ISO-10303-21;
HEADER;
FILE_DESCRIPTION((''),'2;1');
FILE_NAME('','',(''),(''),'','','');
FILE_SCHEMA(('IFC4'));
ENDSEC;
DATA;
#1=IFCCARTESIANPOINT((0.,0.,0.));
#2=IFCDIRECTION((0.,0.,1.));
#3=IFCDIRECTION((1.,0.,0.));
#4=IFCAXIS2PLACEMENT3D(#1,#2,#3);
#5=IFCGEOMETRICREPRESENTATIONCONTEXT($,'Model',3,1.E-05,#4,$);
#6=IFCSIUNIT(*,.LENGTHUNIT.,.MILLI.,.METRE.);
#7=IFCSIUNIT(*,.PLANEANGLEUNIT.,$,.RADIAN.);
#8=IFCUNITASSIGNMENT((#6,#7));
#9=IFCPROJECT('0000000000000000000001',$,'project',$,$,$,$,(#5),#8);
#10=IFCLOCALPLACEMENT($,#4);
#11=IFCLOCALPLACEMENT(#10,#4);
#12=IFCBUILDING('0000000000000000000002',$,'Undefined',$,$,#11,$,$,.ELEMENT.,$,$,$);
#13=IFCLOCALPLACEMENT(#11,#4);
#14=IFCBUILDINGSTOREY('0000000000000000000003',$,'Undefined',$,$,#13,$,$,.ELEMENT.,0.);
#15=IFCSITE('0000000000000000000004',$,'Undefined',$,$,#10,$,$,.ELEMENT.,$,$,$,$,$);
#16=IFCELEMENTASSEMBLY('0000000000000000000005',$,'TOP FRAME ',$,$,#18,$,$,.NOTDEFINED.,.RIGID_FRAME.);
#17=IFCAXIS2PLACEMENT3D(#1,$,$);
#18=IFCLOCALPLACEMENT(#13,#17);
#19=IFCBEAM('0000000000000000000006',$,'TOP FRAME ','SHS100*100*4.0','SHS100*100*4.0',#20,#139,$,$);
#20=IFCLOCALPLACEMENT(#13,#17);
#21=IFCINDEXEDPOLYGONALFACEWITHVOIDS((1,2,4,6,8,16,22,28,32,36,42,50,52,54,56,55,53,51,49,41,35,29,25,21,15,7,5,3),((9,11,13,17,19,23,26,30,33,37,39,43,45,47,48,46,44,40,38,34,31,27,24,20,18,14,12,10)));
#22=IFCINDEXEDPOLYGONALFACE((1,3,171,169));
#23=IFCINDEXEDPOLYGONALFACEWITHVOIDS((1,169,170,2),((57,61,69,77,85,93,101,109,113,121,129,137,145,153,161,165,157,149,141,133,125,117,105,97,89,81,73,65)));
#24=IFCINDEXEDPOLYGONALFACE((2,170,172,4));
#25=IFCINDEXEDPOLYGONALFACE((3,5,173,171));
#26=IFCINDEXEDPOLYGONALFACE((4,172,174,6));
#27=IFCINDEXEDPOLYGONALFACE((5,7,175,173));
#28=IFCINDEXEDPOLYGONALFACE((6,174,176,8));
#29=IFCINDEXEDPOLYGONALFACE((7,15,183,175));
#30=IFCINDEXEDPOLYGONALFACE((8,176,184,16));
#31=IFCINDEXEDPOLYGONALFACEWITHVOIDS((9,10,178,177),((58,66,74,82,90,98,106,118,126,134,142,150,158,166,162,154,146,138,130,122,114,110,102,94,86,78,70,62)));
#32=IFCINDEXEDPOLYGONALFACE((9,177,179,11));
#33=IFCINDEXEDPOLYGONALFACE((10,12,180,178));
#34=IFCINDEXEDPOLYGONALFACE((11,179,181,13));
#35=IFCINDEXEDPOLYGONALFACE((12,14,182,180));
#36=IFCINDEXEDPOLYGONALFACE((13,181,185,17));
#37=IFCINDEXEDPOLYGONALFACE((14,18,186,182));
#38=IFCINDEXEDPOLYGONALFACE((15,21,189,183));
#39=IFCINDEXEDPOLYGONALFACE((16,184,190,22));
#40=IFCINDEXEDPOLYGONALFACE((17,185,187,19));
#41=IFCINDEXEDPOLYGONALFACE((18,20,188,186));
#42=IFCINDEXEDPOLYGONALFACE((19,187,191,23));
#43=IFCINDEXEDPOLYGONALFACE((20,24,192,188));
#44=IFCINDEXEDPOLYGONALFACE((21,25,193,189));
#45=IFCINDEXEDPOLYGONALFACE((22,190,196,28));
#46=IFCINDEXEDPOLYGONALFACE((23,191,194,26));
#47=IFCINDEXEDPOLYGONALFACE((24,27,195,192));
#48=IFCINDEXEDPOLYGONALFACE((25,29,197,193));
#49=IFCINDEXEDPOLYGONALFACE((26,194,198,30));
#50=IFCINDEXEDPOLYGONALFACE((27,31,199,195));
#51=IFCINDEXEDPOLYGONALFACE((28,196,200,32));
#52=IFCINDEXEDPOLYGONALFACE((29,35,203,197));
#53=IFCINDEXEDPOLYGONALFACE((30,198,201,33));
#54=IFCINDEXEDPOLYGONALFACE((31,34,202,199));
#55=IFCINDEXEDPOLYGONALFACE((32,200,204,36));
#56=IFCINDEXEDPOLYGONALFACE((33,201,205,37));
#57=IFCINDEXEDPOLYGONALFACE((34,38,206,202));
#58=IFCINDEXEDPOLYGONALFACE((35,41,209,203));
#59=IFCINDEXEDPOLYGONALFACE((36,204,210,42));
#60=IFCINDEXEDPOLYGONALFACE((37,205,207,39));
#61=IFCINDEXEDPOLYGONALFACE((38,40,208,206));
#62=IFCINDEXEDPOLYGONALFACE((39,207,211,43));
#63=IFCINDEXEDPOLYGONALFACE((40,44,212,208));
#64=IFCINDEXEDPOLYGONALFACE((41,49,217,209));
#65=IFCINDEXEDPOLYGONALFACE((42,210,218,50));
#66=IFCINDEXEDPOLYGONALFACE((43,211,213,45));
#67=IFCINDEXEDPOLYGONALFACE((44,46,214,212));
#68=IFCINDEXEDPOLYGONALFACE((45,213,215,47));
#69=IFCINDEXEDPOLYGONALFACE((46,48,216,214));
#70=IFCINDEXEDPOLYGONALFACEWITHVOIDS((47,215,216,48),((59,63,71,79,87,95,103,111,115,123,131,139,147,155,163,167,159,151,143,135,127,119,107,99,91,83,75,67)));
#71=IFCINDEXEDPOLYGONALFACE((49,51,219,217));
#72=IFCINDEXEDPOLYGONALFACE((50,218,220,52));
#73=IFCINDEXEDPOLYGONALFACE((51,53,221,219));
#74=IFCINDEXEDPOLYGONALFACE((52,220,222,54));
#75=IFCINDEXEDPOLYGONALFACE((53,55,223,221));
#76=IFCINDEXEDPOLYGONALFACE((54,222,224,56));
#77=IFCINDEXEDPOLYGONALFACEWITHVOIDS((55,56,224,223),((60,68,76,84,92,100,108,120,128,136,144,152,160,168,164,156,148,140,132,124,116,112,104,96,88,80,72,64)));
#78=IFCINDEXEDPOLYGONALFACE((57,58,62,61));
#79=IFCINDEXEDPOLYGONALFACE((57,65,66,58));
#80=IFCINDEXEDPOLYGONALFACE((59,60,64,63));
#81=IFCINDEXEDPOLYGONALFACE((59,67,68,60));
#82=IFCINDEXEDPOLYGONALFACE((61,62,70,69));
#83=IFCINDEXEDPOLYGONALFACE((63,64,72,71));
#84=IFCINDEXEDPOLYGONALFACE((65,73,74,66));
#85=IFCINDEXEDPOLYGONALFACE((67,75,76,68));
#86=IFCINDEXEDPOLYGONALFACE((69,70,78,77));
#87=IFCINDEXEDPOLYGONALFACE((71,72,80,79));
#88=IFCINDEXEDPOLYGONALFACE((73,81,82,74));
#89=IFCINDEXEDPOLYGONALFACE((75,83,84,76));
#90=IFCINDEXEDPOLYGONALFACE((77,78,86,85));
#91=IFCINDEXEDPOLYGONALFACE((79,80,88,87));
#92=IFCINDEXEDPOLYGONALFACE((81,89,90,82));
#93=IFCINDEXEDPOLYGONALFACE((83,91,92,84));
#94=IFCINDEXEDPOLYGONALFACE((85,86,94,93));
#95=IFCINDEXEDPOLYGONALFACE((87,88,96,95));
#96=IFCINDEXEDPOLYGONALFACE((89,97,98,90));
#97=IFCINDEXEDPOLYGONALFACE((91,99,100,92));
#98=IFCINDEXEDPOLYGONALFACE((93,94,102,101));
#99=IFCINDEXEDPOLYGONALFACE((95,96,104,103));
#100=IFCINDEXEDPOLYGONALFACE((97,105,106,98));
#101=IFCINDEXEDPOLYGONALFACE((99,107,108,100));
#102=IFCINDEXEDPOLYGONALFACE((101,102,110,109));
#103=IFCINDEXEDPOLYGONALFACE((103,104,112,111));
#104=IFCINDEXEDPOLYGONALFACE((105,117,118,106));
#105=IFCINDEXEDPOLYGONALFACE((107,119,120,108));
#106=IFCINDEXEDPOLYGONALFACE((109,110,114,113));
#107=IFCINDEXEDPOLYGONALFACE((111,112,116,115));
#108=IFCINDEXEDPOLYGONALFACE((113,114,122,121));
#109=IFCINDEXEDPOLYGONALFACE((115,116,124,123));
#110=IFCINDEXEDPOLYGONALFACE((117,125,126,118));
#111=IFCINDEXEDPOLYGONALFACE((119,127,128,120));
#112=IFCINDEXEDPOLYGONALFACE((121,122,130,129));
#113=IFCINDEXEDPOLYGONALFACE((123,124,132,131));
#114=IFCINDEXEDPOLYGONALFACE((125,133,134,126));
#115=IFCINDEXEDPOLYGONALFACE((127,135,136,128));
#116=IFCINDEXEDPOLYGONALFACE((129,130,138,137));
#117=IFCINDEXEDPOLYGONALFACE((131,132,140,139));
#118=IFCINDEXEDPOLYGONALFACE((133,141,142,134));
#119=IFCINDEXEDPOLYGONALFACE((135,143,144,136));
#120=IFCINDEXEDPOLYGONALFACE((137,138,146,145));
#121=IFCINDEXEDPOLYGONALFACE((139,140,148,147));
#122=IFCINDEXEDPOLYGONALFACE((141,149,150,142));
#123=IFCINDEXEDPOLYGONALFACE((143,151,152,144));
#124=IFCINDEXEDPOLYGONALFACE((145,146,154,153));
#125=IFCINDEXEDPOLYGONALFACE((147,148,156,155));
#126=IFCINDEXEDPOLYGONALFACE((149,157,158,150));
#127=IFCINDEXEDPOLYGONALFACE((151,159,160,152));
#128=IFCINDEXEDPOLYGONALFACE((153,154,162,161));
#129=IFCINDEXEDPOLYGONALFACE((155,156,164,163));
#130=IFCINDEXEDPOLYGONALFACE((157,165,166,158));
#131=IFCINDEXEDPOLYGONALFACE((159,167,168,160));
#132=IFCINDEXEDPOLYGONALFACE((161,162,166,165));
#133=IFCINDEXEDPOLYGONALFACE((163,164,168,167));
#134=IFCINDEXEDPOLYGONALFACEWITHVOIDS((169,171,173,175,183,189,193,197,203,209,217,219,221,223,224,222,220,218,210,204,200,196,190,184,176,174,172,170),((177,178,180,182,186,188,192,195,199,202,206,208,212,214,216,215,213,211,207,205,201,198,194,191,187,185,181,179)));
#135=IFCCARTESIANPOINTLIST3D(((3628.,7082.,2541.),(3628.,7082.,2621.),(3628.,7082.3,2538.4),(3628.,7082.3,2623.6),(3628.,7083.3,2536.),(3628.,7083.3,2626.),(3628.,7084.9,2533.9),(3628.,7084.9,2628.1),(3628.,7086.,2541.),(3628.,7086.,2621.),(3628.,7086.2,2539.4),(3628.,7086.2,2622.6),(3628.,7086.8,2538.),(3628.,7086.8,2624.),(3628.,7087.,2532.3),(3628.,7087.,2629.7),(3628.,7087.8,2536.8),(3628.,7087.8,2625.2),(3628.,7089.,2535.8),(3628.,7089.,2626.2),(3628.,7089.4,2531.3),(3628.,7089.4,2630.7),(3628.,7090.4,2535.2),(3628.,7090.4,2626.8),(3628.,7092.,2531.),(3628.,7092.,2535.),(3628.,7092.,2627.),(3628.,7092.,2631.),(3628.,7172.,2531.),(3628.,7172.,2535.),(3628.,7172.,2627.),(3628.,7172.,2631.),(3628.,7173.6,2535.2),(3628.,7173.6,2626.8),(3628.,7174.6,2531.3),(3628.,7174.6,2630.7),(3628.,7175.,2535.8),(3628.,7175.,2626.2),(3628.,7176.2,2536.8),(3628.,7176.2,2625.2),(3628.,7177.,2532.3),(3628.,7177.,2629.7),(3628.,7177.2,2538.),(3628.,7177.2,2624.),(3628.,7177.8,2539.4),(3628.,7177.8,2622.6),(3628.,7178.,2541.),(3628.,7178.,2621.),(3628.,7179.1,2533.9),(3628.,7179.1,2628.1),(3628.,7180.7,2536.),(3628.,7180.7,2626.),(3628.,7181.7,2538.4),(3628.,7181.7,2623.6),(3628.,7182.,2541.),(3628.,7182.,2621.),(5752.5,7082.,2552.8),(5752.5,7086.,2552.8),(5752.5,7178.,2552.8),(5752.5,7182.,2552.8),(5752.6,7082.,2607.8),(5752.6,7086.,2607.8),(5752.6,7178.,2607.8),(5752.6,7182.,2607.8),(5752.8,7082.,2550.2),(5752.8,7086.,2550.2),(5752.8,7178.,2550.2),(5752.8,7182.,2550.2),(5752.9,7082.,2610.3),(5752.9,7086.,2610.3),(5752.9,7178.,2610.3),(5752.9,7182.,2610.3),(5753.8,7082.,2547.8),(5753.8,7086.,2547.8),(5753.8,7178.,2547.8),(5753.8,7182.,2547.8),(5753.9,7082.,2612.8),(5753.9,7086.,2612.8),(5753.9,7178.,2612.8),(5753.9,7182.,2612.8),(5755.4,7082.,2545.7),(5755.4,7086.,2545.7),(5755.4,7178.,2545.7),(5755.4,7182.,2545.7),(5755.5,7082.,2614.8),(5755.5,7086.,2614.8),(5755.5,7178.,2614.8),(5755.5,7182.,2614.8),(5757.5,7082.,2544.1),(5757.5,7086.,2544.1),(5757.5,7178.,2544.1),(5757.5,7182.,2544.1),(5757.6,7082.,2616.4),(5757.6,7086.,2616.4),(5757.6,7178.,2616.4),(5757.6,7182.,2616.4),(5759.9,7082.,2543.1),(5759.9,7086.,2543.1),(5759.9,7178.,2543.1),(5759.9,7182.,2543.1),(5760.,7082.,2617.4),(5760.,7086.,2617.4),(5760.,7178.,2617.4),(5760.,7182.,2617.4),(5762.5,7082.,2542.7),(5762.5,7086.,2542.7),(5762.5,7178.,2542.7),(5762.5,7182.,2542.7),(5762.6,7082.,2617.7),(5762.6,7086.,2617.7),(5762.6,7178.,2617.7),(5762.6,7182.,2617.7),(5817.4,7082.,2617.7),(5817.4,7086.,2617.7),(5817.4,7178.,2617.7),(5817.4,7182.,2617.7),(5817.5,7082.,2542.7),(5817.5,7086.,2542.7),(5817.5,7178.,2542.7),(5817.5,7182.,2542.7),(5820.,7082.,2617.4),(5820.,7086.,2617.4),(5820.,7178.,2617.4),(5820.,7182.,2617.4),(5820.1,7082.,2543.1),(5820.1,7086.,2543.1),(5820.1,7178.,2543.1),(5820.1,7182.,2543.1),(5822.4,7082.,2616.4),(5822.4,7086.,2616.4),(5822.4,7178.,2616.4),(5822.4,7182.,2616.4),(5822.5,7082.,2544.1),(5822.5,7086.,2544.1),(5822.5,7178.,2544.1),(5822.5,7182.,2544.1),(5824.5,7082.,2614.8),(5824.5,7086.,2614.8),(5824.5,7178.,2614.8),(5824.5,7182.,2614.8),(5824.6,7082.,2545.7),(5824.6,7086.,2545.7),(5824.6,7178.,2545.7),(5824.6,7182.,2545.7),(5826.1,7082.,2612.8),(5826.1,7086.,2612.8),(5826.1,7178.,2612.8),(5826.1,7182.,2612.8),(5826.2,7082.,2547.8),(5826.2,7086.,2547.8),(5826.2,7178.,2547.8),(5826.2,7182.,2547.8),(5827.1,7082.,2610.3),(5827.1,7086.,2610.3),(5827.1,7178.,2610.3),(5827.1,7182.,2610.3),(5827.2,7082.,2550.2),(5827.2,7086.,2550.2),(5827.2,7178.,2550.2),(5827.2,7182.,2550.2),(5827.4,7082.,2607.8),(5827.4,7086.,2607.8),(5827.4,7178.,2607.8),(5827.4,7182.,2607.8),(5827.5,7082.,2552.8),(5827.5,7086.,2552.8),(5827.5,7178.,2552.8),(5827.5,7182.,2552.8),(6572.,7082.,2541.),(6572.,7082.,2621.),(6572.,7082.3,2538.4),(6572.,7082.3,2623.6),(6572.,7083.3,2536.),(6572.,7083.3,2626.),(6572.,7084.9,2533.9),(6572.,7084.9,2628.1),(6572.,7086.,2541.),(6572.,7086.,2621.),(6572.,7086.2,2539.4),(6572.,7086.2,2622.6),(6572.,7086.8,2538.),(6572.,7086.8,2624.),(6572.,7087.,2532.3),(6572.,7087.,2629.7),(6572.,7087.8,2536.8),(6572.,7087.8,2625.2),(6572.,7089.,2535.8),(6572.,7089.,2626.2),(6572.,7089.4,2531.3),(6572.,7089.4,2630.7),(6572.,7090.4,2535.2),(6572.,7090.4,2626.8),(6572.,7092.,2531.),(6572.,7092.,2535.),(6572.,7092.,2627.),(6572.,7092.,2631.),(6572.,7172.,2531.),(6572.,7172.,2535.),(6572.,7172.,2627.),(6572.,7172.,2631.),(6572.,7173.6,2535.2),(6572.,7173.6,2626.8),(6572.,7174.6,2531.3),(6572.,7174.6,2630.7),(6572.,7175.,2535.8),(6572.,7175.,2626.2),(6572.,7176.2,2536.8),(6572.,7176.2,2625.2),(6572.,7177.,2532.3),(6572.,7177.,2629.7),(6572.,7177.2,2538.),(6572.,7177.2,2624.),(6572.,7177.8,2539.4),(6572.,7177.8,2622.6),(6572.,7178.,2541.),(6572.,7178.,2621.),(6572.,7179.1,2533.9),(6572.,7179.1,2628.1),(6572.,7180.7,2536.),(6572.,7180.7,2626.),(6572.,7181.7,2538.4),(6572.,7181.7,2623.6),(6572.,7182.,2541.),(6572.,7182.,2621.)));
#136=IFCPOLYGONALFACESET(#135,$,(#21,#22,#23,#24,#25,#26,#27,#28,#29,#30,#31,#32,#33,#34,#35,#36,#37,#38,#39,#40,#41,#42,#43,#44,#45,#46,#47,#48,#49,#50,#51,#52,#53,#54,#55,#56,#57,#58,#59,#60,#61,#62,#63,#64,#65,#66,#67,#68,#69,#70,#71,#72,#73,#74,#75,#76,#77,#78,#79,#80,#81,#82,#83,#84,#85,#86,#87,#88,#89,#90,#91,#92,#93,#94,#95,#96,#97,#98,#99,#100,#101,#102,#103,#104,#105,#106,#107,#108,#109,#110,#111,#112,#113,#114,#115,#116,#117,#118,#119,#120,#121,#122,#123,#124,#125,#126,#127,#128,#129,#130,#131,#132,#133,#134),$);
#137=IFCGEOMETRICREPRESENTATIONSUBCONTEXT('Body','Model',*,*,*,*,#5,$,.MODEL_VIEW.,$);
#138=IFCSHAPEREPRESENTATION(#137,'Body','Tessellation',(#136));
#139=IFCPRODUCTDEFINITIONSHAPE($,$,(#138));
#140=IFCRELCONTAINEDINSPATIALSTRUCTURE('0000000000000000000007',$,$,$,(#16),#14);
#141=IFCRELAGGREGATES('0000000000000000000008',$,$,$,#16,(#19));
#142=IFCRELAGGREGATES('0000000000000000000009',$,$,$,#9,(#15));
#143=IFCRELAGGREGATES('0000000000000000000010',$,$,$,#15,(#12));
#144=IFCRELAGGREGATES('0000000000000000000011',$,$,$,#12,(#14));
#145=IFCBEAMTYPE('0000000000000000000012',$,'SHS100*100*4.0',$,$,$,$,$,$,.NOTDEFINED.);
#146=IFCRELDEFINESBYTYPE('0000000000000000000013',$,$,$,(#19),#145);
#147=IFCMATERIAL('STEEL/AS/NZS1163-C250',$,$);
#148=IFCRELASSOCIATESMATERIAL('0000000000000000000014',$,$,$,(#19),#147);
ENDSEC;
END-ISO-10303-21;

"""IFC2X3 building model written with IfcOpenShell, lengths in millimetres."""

from ifc_helpers import new_model, si_unit, frame, frame_2d, origin_with_axes, origin_2d_with_axis, place, context, subcontext, project, spatial, polyline, circle_curve, parameter, trimmed, segment, composite_curve, hollow_rectangle, outline, extrude, boolean, material, type_object, element, aggregate, save


model = new_model("IFC2X3")

# Units and contexts
model_context = context("Model", 3, precision=1e-05, world=origin_with_axes())
body_context = subcontext(model_context, "Body", "Model", "MODEL_VIEW")
ifc_project = project(units=[si_unit("LENGTHUNIT", "METRE", prefix="MILLI"), si_unit("PLANEANGLEUNIT", "RADIAN")], contexts=[model_context])

# Site, building, storey
site_placement = place(None, origin_with_axes())
site = spatial("IfcSite", under=ifc_project, at=site_placement, Name="Undefined", CompositionType="ELEMENT")
building_placement = place(site_placement, origin_with_axes())
building = spatial("IfcBuilding", under=site, at=building_placement, Name="Undefined", CompositionType="ELEMENT")
storey_placement = place(building_placement, origin_with_axes())
storey = spatial("IfcBuildingStorey", under=building, at=storey_placement, Name="Undefined", CompositionType="ELEMENT", Elevation=0.0)

# Element assembly
ifc_material_1 = material(Name="STEEL/AS/NZS1163-C250")
assembly_1_placement = place(storey_placement, origin_with_axes())
assembly_1 = element("IfcElementAssembly", 1, at=assembly_1_placement, inside=storey, Name="TOP FRAME ", AssemblyPlace="NOTDEFINED", PredefinedType="RIGID_FRAME")

# Beam
beam_type_1 = type_object("IfcBeamType", Name="SHS100*100*4.0", PredefinedType="NOTDEFINED")
beam_1_placement = place(assembly_1_placement, frame((6572.0, 7132.0, 2581.0), z_axis=(0.0, 0.0, 1.0), x_axis=(-1.0, 0.0, 0.0)))
beam_1 = element("IfcBeam", 2, at=beam_1_placement, type_object=beam_type_1, material=ifc_material_1, Name="TOP FRAME ", Description="SHS100*100*4.0", ObjectType="SHS100*100*4.0", context=body_context, shape_type="CSG", body=[
    boolean("DIFFERENCE", extrude(hollow_rectangle(XDim=100.0, YDim=100.0, WallThickness=4.0, InnerFilletRadius=6.0, OuterFilletRadius=10.0, at=origin_2d_with_axis()), frame((2944.0, 0.0, 0.0), z_axis=(-1.0, 0.0, 0.0), x_axis=(0.0, -1.0, 0.0)), (0.0, 0.0, 1.0), 2944.0), extrude(outline(composite_curve([segment(trimmed(circle_curve(frame_2d((10.0, 10.0), x_axis=(-0.999999, -0.001138)), 10.0), [parameter(0.0)], [parameter(1.569658)], True, "PARAMETER"), True, "CONTINUOUS"), segment(polyline([(10.0, 0.0), (64.8, 0.0)]), True, "CONTINUOUS"), segment(trimmed(circle_curve(frame_2d((64.8, 10.0), x_axis=(0.0, -1.0)), 10.0), [parameter(0.0)], [parameter(1.569658)], True, "PARAMETER"), True, "CONTINUOUS"), segment(polyline([(74.8, 10.0), (74.9, 65.0)]), True, "CONTINUOUS"), segment(trimmed(circle_curve(frame_2d((64.9, 65.0), x_axis=(0.999999, -0.001138)), 10.0), [parameter(0.0)], [parameter(1.571934)], True, "PARAMETER"), True, "CONTINUOUS"), segment(polyline([(64.9, 75.0), (9.9, 75.0)]), True, "CONTINUOUS"), segment(trimmed(circle_curve(frame_2d((9.9, 65.0), x_axis=(0.0, 1.0)), 10.0), [parameter(0.0)], [parameter(1.571934)], True, "PARAMETER"), True, "CONTINUOUS"), segment(polyline([(-0.1, 65.0), (0.0, 10.0)]), True, "CONTINUOUS")], self_intersect=True)), frame((819.4, 53.0, 36.7), z_axis=(-0.000004, -1.0, 0.0), x_axis=(-1.0, 0.000004, 0.0)), (0.0, 0.0, 1.0), 106.0)),
])
aggregate(assembly_1, [beam_1])

save(model, "model.ifc")
